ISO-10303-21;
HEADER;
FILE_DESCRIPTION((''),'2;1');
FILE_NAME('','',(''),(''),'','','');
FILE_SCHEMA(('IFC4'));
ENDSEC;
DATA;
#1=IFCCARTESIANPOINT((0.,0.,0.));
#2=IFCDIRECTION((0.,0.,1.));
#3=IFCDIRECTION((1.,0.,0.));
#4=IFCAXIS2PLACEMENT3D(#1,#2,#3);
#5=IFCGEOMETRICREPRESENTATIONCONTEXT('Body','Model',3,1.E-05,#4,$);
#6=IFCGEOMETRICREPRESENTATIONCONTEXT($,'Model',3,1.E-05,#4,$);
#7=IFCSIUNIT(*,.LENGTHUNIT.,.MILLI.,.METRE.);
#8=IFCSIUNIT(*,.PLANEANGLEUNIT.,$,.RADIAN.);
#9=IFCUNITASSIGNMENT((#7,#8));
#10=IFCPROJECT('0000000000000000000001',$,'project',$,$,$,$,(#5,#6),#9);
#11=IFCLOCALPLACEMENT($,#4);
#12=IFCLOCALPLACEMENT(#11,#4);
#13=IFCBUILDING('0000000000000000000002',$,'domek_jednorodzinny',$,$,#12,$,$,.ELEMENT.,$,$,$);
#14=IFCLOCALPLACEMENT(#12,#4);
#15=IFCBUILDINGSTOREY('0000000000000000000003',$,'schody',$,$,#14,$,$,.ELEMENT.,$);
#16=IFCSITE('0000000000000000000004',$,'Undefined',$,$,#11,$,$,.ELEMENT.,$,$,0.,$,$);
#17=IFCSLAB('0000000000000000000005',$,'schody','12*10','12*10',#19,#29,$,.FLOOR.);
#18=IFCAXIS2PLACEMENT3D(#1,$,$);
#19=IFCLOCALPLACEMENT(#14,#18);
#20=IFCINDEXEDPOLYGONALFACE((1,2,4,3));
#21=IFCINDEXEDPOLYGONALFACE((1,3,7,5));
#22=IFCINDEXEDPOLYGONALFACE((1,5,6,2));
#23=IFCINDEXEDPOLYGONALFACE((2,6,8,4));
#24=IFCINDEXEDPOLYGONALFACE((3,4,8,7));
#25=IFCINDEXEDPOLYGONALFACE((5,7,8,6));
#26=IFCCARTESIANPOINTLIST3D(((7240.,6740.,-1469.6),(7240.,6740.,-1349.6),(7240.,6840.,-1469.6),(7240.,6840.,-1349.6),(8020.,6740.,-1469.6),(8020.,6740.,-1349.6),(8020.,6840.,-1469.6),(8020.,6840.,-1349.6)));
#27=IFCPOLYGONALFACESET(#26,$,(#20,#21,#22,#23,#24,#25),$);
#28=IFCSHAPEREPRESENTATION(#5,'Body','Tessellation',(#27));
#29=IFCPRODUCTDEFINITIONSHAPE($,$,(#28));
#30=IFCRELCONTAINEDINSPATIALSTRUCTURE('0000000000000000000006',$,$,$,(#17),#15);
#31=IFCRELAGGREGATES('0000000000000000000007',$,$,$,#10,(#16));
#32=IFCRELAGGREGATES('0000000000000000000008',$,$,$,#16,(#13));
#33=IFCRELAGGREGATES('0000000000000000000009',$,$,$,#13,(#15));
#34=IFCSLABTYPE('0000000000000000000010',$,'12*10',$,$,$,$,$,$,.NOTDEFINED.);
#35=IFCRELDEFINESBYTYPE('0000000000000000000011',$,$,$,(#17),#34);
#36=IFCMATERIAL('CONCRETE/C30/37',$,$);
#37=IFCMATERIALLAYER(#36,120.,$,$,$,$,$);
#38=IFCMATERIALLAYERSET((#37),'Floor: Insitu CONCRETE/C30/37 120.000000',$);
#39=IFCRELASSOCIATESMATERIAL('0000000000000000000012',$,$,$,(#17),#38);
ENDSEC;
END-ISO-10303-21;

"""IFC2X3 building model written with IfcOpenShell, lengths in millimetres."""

from ifc_helpers import new_model, si_unit, frame, origin_with_axes, place, context, project, spatial, polyline, outline, extrude, material, layer, layer_set, layer_usage, type_object, element, save


model = new_model("IFC2X3")

# Units and contexts
model_context_1 = context("Model", 3, precision=1e-05, world=origin_with_axes(), identifier="Body")
model_context_2 = context("Model", 3, precision=1e-05, world=origin_with_axes())
ifc_project = project(units=[si_unit("LENGTHUNIT", "METRE", prefix="MILLI"), si_unit("PLANEANGLEUNIT", "RADIAN")], contexts=[model_context_1, model_context_2])

# Site, building, storey
site_placement = place(None, origin_with_axes())
site = spatial("IfcSite", under=ifc_project, at=site_placement, Name="Undefined", CompositionType="ELEMENT", RefElevation=0.0)
building_placement = place(site_placement, origin_with_axes())
building = spatial("IfcBuilding", under=site, at=building_placement, Name="domek_jednorodzinny", CompositionType="ELEMENT")
storey_placement = place(building_placement, origin_with_axes())
storey = spatial("IfcBuildingStorey", under=building, at=storey_placement, Name="schody", CompositionType="ELEMENT")

# Slab
ifc_material = material(Name="CONCRETE/C30/37")
ifc_layer_1 = layer(ifc_material, 120.0)
ifc_layer_set_1 = layer_set([ifc_layer_1], Name="Floor: Insitu CONCRETE/C30/37 120.000000")
ifc_layer_usage_1 = layer_usage(ifc_layer_set_1, "AXIS3", "POSITIVE", -60.0)
slab_type_1 = type_object("IfcSlabType", Name="12*10", PredefinedType="NOTDEFINED")
slab_1_placement = place(storey_placement, frame((7240.0, 6840.0, -1409.6), z_axis=(0.000001, 0.000001, -1.0), x_axis=(1.0, 0.0, 0.0)))
element("IfcSlab", 1, at=slab_1_placement, inside=storey, type_object=slab_type_1, material=ifc_layer_usage_1, Name="schody", Description="12*10", ObjectType="12*10", PredefinedType="FLOOR", context=model_context_1, shape_type="SweptSolid", body=[
    extrude(outline(polyline([(0.0, 0.0), (780.0, 0.0), (780.0, 100.0), (0.0, 100.0), (0.0, 0.0)])), frame((0.0, 0.0, -60.0), z_axis=(0.0, 0.0, 1.0), x_axis=(1.0, 0.0, 0.0)), (0.0, 0.0, 1.0), 120.0),
])

save(model, "model.ifc")
